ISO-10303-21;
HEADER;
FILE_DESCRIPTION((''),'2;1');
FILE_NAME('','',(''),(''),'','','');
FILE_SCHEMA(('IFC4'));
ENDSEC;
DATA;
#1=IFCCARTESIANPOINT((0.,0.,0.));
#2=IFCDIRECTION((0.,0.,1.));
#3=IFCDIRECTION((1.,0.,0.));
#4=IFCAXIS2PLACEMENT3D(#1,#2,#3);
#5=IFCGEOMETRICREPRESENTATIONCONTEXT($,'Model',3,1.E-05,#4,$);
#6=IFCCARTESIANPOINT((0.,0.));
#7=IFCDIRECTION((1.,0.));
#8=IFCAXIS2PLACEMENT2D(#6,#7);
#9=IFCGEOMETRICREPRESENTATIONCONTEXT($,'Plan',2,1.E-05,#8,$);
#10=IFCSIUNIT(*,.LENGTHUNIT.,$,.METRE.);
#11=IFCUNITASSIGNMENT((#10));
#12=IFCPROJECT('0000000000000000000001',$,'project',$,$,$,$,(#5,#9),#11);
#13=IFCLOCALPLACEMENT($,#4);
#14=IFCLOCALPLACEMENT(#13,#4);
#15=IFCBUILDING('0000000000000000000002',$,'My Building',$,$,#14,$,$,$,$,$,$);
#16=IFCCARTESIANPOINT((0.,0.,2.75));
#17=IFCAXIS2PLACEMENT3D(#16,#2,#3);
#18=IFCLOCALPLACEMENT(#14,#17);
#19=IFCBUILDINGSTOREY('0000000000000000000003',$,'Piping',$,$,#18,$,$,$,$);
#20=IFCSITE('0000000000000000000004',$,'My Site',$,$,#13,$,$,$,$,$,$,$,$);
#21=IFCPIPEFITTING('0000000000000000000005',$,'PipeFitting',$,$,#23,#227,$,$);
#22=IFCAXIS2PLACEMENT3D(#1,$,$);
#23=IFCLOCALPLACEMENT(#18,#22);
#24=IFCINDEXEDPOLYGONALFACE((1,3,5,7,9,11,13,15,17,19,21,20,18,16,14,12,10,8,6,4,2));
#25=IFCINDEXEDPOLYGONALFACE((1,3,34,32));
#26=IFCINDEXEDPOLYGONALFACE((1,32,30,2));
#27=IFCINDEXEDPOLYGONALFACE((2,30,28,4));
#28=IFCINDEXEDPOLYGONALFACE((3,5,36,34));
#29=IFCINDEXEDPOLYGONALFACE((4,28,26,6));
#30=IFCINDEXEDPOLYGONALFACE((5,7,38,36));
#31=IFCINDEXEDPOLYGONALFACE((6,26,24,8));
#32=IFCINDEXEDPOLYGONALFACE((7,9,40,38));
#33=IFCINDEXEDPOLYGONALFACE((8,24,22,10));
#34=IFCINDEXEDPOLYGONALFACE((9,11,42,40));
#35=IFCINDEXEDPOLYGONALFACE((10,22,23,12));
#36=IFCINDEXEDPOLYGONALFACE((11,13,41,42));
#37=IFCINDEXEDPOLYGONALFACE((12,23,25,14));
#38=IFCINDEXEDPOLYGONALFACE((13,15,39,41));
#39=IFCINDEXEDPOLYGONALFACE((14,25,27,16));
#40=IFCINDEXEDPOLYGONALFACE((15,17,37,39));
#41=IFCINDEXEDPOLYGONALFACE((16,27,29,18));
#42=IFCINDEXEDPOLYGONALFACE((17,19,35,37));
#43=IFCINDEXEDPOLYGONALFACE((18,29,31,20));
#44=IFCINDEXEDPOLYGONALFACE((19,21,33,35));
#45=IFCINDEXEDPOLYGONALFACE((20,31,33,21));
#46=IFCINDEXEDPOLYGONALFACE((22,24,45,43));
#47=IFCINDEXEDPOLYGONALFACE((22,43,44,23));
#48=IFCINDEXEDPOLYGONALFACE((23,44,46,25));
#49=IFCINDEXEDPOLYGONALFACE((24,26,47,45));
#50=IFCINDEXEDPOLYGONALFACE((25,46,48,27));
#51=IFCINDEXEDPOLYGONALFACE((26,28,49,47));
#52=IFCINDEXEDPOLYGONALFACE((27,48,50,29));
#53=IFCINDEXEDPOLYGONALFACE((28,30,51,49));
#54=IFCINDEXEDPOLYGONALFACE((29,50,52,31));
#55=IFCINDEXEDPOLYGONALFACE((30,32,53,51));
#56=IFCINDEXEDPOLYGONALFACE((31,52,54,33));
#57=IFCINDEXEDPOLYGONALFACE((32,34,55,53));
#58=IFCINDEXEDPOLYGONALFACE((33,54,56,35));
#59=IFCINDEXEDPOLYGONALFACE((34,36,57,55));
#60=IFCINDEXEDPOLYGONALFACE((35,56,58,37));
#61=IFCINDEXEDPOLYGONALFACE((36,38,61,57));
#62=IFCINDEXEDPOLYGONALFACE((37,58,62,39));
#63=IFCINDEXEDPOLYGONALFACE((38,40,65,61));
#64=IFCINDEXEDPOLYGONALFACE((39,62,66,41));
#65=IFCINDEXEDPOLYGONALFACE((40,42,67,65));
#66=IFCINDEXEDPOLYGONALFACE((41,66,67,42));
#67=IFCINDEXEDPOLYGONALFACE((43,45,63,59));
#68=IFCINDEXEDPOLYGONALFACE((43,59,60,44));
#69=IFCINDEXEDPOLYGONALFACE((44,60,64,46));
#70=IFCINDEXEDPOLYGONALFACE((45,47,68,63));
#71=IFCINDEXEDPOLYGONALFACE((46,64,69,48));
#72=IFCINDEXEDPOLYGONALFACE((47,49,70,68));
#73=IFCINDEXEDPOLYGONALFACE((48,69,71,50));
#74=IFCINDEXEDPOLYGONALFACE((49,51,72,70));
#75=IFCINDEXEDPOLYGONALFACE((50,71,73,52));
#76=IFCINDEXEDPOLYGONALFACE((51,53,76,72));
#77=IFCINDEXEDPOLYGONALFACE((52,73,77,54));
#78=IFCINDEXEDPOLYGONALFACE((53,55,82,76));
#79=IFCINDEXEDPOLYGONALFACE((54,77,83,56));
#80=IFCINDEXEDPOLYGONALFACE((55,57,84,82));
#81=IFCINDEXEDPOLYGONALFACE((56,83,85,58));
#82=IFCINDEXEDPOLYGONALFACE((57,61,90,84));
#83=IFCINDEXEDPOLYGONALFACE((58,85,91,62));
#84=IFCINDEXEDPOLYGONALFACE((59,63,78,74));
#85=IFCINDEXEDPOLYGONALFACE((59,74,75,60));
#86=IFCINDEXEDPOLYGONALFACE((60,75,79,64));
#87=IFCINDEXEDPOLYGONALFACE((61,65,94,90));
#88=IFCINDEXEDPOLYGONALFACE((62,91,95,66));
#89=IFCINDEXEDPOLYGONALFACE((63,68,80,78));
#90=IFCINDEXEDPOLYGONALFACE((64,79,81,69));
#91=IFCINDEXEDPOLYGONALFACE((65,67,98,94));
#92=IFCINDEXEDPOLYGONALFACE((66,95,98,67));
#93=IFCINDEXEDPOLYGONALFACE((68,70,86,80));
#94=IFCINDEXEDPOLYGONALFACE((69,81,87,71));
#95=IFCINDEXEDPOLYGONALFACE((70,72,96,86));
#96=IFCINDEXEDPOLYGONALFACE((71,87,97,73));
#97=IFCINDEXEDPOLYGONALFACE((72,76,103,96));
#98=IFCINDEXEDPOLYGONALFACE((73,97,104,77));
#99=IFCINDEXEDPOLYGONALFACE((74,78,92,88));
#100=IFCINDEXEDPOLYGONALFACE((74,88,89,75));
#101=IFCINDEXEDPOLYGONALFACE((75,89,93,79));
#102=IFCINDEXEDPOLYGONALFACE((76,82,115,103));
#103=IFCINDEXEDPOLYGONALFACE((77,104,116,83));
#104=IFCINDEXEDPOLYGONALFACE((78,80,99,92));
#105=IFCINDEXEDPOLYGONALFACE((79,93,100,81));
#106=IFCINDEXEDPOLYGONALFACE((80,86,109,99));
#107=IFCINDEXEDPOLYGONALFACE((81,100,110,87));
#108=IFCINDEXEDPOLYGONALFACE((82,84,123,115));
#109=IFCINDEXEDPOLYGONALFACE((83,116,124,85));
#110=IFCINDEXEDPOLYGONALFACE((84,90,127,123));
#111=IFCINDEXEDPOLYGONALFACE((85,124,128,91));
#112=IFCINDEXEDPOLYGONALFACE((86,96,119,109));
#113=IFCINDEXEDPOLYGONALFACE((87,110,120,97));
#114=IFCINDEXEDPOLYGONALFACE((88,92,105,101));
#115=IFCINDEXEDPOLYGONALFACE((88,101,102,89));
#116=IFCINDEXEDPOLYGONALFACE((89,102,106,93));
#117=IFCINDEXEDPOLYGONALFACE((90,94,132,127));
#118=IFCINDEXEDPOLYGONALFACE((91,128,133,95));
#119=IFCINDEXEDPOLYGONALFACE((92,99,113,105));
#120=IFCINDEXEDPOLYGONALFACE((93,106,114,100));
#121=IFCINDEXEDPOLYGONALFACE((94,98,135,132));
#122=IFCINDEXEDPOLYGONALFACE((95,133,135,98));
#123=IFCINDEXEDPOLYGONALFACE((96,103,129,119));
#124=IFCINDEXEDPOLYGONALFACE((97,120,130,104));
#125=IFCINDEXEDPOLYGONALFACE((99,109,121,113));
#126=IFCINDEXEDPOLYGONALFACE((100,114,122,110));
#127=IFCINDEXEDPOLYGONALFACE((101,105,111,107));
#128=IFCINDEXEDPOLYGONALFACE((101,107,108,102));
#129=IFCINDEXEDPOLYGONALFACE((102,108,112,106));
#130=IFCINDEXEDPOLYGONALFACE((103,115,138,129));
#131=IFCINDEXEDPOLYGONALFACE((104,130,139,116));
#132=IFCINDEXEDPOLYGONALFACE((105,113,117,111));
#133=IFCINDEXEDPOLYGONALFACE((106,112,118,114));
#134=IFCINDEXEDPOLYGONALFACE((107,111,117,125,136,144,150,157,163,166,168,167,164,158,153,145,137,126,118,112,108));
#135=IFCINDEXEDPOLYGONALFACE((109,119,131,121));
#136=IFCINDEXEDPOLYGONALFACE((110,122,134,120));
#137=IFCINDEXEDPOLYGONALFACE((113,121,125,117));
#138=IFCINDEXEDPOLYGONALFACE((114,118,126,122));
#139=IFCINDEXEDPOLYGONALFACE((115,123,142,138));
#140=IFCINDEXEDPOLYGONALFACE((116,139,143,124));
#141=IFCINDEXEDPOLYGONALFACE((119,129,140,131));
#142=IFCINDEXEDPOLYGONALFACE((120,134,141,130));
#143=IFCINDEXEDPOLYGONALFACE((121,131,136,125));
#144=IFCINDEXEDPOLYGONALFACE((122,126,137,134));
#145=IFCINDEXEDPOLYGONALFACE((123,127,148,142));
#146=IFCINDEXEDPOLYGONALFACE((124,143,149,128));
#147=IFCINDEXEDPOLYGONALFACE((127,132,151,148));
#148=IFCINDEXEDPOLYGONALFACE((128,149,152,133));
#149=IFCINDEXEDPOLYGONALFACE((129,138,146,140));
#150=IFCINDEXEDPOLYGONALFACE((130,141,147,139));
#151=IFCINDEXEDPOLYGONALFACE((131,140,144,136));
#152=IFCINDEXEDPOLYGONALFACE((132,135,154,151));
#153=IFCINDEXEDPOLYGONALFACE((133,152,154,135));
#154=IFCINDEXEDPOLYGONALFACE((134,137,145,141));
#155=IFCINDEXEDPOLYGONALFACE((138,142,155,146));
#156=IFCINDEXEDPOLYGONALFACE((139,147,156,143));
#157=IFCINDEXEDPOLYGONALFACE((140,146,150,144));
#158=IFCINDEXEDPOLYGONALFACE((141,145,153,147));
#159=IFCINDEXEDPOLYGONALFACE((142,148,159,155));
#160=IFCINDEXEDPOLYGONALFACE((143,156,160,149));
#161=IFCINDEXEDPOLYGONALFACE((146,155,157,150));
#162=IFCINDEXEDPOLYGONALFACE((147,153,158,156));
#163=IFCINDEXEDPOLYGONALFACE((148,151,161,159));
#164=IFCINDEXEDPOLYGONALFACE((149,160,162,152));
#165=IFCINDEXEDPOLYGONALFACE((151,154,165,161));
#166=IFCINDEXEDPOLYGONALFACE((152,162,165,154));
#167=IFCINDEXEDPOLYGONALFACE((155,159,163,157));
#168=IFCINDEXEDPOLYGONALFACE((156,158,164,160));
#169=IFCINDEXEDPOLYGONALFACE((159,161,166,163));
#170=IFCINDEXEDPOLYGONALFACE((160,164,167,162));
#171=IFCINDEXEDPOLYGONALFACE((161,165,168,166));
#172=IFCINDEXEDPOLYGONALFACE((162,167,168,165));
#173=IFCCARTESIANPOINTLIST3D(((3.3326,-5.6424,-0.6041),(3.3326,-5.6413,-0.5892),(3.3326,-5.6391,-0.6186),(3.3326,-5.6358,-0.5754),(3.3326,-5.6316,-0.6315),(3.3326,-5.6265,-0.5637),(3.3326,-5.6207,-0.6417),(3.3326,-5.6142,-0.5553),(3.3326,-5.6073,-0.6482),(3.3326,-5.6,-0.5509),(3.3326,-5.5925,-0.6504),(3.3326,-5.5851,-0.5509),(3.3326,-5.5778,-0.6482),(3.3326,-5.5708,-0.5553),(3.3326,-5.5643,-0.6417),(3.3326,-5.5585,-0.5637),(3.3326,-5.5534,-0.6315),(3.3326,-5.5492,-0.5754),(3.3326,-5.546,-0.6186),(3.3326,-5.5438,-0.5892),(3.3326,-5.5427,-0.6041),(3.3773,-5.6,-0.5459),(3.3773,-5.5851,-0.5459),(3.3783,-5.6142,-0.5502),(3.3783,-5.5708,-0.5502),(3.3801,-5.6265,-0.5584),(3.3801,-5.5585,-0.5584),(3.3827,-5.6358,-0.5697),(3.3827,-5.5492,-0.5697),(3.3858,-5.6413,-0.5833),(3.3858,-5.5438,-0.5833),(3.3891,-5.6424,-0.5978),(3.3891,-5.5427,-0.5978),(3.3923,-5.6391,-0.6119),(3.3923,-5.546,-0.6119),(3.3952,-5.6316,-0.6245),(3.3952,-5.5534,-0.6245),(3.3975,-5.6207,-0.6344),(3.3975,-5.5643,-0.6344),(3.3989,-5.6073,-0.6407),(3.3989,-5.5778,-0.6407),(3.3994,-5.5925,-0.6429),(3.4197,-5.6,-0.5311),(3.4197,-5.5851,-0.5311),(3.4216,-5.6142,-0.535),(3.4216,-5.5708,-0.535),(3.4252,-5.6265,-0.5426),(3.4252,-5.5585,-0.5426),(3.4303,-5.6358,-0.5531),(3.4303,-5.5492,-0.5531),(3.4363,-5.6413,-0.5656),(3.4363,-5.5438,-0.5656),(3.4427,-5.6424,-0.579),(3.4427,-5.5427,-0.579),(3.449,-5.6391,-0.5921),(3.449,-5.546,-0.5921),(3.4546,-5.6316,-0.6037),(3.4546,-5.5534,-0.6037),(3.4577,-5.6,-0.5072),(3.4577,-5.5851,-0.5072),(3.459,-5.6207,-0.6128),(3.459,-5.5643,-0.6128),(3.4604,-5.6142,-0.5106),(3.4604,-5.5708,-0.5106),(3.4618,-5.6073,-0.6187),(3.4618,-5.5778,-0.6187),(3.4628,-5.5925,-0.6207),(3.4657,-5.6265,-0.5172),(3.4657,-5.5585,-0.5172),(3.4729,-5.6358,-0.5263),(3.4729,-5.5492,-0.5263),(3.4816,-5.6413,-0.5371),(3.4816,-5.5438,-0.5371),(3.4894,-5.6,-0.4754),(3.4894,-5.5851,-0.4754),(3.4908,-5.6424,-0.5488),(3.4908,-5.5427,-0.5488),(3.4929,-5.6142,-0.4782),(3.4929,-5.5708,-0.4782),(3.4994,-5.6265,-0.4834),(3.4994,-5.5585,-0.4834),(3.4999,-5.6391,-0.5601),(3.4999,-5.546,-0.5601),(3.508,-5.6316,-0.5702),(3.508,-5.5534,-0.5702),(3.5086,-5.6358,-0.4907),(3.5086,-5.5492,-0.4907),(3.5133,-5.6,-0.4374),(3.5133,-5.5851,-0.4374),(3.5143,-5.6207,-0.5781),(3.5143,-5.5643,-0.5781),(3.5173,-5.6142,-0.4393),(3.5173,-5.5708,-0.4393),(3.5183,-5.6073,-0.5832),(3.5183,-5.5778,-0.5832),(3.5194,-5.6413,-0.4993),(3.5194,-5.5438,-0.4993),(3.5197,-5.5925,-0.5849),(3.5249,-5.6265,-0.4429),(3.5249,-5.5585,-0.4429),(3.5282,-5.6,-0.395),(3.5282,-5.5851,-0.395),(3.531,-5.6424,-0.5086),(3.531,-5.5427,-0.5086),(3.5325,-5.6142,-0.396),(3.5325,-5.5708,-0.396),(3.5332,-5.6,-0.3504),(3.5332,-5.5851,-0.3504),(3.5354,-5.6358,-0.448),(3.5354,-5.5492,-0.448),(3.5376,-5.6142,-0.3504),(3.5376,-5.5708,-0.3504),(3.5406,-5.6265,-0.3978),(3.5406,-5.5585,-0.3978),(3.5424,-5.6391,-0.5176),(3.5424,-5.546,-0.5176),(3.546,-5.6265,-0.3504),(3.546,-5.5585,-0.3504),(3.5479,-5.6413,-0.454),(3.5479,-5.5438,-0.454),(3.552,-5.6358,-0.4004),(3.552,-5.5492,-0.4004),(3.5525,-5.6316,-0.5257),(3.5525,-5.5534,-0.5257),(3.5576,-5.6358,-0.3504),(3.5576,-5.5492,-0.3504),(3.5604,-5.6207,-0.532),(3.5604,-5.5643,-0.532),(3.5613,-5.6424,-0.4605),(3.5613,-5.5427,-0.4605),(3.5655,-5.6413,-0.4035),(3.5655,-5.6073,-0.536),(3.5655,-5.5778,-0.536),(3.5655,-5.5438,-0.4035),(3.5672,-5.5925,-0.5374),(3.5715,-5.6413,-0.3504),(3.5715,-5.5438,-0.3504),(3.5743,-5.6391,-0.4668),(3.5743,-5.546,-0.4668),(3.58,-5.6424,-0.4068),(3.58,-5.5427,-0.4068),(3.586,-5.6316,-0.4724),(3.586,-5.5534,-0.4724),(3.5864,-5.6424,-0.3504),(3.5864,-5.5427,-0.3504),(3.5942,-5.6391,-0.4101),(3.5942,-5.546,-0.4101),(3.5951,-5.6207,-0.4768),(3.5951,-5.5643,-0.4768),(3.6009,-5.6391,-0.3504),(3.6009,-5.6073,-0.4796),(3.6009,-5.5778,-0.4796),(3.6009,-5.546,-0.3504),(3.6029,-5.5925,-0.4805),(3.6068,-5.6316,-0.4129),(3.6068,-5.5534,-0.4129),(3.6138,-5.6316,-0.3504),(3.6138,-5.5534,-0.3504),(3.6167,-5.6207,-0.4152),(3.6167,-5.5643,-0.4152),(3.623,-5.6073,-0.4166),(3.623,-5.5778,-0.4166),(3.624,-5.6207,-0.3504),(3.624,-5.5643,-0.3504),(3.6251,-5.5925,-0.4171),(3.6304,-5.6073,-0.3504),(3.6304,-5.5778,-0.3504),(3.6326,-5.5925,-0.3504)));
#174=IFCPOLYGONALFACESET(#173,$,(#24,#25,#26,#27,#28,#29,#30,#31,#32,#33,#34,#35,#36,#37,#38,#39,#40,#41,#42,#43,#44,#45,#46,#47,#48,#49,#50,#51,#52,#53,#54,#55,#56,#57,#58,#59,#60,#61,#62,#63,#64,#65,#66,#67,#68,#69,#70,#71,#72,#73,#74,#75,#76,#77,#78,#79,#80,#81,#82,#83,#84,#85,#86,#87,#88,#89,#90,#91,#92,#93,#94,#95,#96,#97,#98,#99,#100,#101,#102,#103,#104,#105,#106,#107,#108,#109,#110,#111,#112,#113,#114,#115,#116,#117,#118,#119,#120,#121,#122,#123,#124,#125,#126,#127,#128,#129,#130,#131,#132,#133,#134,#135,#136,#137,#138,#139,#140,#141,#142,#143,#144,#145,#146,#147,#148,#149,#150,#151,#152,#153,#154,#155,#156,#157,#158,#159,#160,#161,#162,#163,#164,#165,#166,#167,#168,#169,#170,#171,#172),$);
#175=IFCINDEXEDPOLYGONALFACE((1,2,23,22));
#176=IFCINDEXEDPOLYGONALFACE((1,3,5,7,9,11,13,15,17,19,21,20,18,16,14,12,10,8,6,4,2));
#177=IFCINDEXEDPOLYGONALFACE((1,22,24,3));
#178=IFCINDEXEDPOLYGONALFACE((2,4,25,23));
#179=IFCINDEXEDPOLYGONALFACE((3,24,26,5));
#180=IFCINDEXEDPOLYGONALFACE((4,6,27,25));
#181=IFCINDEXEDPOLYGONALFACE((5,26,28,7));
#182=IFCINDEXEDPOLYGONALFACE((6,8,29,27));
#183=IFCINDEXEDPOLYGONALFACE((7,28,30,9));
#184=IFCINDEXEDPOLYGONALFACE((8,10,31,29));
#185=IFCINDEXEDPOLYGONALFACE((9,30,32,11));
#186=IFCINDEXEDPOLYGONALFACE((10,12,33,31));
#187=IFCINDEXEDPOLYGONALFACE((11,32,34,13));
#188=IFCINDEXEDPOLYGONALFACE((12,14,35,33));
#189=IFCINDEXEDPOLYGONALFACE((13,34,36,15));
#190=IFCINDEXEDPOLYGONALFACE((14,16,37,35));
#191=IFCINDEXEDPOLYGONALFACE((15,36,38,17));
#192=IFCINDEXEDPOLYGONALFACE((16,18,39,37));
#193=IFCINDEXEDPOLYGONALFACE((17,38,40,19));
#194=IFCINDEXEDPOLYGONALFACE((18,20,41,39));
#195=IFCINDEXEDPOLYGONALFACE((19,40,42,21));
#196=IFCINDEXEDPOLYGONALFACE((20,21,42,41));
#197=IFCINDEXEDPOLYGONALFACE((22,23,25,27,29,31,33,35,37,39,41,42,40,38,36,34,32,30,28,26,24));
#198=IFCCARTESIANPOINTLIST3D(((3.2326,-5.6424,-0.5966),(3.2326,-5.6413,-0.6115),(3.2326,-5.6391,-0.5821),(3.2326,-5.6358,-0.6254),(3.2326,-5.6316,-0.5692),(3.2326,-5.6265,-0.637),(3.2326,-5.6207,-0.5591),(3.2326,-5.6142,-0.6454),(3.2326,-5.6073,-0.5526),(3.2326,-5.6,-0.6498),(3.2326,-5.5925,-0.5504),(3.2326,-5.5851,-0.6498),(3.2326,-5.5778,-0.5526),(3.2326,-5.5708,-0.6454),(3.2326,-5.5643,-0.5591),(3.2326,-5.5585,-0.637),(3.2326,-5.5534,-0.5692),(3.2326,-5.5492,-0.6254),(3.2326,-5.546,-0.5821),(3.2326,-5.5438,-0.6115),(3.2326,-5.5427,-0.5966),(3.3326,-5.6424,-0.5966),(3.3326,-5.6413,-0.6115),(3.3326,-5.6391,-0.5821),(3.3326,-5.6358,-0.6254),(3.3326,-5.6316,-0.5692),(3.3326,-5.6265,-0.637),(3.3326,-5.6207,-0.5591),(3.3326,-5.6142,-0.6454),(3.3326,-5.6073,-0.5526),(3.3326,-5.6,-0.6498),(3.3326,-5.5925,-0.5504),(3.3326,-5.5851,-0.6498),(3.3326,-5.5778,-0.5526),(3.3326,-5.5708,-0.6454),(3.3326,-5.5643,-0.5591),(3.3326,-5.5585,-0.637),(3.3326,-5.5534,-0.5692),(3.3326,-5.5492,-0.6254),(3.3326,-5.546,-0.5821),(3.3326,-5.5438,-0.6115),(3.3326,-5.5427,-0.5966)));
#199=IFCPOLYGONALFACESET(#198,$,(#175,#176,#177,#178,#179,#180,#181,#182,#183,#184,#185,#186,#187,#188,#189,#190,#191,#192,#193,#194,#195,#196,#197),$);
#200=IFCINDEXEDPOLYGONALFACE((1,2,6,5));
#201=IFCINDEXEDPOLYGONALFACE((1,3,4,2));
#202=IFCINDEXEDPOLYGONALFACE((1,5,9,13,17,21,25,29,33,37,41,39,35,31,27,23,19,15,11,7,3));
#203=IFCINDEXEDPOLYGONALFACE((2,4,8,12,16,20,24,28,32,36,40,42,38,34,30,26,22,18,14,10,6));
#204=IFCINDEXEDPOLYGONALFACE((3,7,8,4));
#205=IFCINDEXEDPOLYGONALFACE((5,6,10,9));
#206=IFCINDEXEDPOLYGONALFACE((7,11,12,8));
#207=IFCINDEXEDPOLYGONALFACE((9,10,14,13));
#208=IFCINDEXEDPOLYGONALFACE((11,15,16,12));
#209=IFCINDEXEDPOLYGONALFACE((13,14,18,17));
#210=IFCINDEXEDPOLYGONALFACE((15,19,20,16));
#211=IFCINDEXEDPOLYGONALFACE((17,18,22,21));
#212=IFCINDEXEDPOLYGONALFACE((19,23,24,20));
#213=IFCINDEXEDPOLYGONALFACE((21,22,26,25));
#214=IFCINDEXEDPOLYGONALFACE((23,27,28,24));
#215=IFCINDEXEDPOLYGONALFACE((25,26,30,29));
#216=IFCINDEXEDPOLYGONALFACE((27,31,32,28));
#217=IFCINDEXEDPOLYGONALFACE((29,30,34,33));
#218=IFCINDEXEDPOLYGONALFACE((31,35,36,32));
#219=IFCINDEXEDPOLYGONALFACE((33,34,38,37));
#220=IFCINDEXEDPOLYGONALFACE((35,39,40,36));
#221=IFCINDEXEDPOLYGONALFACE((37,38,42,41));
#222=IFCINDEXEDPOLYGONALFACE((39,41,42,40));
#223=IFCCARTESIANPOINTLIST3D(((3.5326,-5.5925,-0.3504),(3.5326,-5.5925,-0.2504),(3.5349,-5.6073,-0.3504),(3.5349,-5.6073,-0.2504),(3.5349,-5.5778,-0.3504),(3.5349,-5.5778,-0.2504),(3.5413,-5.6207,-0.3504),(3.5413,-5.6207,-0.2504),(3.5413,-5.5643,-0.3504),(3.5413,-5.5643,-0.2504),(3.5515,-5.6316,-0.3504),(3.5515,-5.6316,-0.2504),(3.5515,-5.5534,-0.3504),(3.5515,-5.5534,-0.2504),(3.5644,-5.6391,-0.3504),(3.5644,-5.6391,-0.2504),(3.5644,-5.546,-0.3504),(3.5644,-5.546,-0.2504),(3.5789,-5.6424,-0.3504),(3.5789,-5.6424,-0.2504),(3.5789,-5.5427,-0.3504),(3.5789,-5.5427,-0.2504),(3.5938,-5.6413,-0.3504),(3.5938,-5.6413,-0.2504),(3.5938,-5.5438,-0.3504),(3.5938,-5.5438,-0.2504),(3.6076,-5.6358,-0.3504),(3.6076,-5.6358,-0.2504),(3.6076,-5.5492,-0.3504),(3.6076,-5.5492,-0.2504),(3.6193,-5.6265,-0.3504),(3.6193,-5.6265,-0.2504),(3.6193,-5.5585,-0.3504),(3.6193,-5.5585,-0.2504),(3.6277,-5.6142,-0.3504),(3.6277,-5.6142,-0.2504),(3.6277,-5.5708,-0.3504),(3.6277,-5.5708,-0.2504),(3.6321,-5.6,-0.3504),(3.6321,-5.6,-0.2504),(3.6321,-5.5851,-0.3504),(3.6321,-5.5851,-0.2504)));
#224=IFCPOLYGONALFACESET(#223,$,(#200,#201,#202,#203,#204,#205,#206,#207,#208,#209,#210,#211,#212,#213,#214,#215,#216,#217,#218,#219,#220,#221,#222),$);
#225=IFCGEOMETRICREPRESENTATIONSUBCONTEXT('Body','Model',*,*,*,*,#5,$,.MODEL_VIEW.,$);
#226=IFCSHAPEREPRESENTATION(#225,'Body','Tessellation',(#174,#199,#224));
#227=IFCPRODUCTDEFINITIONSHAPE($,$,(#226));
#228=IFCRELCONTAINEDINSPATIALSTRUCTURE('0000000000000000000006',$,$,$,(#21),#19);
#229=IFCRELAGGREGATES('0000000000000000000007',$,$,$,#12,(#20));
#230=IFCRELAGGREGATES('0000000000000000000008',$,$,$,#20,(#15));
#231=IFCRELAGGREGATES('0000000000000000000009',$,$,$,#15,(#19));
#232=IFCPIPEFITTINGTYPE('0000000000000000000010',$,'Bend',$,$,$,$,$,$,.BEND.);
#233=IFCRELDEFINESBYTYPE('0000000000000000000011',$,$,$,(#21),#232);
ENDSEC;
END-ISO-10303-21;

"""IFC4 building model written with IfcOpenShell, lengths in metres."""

from ifc_helpers import new_model, entity, si_unit, frame, origin_with_axes, origin_2d_with_axis, place, context, subcontext, project, spatial, circle, extrude, source, transform, mapped, type_object, type_shapes, element, save


model = new_model("IFC4")

# Units and contexts
model_context = context("Model", 3, precision=1e-05, world=origin_with_axes())
plan_context = context("Plan", 2, precision=1e-05, world=origin_2d_with_axis())
body_context = subcontext(model_context, "Body", "Model", "MODEL_VIEW")
ifc_project = project(units=[si_unit("LENGTHUNIT", "METRE")], contexts=[model_context, plan_context])

# Site, building, storey
site_placement = place(None, origin_with_axes())
site = spatial("IfcSite", under=ifc_project, at=site_placement, Name="My Site")
building_placement = place(site_placement, origin_with_axes())
building = spatial("IfcBuilding", under=site, at=building_placement, Name="My Building")
storey_placement = place(building_placement, frame((0.0, 0.0, 2.75), z_axis=(0.0, 0.0, 1.0), x_axis=(1.0, 0.0, 0.0)))
storey = spatial("IfcBuildingStorey", under=building, at=storey_placement, Name="Piping")

# Pipe fitting
pipe_fitting_type = type_object("IfcPipeFittingType", Name="Bend", PredefinedType="BEND")
shared_shape = source(origin_with_axes(), body_context, "Body", "SolidModel", [
    entity("IfcSweptDiskSolid", entity("IfcIndexedPolyCurve", entity("IfcCartesianPointList3D", [[0.0, 0.0, -0.1], [0.0732, 0.0, -0.2768], [0.25, 0.0, -0.35]]), [entity("IfcArcIndex", [1, 2, 3])]), 0.05),
    extrude(circle(Radius=0.05), origin_with_axes(), (0.0, 0.0, -1.0), 0.1),
    extrude(circle(Radius=0.05), frame((0.25, 0.0, -0.35), z_axis=(1.0, 0.0, 0.0), x_axis=(0.0, 0.0, 1.0)), (0.0, 0.0, 1.0), 0.1),
])
type_shapes(pipe_fitting_type, [shared_shape])
for number, where, z_axis, x_axis, name in (
    (1, (3.2326, -5.5925, -0.6004), (-1.0, 0.0, 0.0), (0.0, 0.0, 1.0), "PipeFitting"),
):
    element("IfcPipeFitting", number, at=place(storey_placement, frame(where, z_axis=z_axis, x_axis=x_axis)), inside=storey, type_object=pipe_fitting_type, Name=name, context=body_context, shape_type="MappedRepresentation", body=[
        mapped(shared_shape, transform((0.0, 0.0, 0.0), x_axis=(1.0, 0.0, 0.0), y_axis=(0.0, 1.0, 0.0), z_axis=(0.0, 0.0, 1.0), scale=1.0)),
    ])

save(model, "model.ifc")
